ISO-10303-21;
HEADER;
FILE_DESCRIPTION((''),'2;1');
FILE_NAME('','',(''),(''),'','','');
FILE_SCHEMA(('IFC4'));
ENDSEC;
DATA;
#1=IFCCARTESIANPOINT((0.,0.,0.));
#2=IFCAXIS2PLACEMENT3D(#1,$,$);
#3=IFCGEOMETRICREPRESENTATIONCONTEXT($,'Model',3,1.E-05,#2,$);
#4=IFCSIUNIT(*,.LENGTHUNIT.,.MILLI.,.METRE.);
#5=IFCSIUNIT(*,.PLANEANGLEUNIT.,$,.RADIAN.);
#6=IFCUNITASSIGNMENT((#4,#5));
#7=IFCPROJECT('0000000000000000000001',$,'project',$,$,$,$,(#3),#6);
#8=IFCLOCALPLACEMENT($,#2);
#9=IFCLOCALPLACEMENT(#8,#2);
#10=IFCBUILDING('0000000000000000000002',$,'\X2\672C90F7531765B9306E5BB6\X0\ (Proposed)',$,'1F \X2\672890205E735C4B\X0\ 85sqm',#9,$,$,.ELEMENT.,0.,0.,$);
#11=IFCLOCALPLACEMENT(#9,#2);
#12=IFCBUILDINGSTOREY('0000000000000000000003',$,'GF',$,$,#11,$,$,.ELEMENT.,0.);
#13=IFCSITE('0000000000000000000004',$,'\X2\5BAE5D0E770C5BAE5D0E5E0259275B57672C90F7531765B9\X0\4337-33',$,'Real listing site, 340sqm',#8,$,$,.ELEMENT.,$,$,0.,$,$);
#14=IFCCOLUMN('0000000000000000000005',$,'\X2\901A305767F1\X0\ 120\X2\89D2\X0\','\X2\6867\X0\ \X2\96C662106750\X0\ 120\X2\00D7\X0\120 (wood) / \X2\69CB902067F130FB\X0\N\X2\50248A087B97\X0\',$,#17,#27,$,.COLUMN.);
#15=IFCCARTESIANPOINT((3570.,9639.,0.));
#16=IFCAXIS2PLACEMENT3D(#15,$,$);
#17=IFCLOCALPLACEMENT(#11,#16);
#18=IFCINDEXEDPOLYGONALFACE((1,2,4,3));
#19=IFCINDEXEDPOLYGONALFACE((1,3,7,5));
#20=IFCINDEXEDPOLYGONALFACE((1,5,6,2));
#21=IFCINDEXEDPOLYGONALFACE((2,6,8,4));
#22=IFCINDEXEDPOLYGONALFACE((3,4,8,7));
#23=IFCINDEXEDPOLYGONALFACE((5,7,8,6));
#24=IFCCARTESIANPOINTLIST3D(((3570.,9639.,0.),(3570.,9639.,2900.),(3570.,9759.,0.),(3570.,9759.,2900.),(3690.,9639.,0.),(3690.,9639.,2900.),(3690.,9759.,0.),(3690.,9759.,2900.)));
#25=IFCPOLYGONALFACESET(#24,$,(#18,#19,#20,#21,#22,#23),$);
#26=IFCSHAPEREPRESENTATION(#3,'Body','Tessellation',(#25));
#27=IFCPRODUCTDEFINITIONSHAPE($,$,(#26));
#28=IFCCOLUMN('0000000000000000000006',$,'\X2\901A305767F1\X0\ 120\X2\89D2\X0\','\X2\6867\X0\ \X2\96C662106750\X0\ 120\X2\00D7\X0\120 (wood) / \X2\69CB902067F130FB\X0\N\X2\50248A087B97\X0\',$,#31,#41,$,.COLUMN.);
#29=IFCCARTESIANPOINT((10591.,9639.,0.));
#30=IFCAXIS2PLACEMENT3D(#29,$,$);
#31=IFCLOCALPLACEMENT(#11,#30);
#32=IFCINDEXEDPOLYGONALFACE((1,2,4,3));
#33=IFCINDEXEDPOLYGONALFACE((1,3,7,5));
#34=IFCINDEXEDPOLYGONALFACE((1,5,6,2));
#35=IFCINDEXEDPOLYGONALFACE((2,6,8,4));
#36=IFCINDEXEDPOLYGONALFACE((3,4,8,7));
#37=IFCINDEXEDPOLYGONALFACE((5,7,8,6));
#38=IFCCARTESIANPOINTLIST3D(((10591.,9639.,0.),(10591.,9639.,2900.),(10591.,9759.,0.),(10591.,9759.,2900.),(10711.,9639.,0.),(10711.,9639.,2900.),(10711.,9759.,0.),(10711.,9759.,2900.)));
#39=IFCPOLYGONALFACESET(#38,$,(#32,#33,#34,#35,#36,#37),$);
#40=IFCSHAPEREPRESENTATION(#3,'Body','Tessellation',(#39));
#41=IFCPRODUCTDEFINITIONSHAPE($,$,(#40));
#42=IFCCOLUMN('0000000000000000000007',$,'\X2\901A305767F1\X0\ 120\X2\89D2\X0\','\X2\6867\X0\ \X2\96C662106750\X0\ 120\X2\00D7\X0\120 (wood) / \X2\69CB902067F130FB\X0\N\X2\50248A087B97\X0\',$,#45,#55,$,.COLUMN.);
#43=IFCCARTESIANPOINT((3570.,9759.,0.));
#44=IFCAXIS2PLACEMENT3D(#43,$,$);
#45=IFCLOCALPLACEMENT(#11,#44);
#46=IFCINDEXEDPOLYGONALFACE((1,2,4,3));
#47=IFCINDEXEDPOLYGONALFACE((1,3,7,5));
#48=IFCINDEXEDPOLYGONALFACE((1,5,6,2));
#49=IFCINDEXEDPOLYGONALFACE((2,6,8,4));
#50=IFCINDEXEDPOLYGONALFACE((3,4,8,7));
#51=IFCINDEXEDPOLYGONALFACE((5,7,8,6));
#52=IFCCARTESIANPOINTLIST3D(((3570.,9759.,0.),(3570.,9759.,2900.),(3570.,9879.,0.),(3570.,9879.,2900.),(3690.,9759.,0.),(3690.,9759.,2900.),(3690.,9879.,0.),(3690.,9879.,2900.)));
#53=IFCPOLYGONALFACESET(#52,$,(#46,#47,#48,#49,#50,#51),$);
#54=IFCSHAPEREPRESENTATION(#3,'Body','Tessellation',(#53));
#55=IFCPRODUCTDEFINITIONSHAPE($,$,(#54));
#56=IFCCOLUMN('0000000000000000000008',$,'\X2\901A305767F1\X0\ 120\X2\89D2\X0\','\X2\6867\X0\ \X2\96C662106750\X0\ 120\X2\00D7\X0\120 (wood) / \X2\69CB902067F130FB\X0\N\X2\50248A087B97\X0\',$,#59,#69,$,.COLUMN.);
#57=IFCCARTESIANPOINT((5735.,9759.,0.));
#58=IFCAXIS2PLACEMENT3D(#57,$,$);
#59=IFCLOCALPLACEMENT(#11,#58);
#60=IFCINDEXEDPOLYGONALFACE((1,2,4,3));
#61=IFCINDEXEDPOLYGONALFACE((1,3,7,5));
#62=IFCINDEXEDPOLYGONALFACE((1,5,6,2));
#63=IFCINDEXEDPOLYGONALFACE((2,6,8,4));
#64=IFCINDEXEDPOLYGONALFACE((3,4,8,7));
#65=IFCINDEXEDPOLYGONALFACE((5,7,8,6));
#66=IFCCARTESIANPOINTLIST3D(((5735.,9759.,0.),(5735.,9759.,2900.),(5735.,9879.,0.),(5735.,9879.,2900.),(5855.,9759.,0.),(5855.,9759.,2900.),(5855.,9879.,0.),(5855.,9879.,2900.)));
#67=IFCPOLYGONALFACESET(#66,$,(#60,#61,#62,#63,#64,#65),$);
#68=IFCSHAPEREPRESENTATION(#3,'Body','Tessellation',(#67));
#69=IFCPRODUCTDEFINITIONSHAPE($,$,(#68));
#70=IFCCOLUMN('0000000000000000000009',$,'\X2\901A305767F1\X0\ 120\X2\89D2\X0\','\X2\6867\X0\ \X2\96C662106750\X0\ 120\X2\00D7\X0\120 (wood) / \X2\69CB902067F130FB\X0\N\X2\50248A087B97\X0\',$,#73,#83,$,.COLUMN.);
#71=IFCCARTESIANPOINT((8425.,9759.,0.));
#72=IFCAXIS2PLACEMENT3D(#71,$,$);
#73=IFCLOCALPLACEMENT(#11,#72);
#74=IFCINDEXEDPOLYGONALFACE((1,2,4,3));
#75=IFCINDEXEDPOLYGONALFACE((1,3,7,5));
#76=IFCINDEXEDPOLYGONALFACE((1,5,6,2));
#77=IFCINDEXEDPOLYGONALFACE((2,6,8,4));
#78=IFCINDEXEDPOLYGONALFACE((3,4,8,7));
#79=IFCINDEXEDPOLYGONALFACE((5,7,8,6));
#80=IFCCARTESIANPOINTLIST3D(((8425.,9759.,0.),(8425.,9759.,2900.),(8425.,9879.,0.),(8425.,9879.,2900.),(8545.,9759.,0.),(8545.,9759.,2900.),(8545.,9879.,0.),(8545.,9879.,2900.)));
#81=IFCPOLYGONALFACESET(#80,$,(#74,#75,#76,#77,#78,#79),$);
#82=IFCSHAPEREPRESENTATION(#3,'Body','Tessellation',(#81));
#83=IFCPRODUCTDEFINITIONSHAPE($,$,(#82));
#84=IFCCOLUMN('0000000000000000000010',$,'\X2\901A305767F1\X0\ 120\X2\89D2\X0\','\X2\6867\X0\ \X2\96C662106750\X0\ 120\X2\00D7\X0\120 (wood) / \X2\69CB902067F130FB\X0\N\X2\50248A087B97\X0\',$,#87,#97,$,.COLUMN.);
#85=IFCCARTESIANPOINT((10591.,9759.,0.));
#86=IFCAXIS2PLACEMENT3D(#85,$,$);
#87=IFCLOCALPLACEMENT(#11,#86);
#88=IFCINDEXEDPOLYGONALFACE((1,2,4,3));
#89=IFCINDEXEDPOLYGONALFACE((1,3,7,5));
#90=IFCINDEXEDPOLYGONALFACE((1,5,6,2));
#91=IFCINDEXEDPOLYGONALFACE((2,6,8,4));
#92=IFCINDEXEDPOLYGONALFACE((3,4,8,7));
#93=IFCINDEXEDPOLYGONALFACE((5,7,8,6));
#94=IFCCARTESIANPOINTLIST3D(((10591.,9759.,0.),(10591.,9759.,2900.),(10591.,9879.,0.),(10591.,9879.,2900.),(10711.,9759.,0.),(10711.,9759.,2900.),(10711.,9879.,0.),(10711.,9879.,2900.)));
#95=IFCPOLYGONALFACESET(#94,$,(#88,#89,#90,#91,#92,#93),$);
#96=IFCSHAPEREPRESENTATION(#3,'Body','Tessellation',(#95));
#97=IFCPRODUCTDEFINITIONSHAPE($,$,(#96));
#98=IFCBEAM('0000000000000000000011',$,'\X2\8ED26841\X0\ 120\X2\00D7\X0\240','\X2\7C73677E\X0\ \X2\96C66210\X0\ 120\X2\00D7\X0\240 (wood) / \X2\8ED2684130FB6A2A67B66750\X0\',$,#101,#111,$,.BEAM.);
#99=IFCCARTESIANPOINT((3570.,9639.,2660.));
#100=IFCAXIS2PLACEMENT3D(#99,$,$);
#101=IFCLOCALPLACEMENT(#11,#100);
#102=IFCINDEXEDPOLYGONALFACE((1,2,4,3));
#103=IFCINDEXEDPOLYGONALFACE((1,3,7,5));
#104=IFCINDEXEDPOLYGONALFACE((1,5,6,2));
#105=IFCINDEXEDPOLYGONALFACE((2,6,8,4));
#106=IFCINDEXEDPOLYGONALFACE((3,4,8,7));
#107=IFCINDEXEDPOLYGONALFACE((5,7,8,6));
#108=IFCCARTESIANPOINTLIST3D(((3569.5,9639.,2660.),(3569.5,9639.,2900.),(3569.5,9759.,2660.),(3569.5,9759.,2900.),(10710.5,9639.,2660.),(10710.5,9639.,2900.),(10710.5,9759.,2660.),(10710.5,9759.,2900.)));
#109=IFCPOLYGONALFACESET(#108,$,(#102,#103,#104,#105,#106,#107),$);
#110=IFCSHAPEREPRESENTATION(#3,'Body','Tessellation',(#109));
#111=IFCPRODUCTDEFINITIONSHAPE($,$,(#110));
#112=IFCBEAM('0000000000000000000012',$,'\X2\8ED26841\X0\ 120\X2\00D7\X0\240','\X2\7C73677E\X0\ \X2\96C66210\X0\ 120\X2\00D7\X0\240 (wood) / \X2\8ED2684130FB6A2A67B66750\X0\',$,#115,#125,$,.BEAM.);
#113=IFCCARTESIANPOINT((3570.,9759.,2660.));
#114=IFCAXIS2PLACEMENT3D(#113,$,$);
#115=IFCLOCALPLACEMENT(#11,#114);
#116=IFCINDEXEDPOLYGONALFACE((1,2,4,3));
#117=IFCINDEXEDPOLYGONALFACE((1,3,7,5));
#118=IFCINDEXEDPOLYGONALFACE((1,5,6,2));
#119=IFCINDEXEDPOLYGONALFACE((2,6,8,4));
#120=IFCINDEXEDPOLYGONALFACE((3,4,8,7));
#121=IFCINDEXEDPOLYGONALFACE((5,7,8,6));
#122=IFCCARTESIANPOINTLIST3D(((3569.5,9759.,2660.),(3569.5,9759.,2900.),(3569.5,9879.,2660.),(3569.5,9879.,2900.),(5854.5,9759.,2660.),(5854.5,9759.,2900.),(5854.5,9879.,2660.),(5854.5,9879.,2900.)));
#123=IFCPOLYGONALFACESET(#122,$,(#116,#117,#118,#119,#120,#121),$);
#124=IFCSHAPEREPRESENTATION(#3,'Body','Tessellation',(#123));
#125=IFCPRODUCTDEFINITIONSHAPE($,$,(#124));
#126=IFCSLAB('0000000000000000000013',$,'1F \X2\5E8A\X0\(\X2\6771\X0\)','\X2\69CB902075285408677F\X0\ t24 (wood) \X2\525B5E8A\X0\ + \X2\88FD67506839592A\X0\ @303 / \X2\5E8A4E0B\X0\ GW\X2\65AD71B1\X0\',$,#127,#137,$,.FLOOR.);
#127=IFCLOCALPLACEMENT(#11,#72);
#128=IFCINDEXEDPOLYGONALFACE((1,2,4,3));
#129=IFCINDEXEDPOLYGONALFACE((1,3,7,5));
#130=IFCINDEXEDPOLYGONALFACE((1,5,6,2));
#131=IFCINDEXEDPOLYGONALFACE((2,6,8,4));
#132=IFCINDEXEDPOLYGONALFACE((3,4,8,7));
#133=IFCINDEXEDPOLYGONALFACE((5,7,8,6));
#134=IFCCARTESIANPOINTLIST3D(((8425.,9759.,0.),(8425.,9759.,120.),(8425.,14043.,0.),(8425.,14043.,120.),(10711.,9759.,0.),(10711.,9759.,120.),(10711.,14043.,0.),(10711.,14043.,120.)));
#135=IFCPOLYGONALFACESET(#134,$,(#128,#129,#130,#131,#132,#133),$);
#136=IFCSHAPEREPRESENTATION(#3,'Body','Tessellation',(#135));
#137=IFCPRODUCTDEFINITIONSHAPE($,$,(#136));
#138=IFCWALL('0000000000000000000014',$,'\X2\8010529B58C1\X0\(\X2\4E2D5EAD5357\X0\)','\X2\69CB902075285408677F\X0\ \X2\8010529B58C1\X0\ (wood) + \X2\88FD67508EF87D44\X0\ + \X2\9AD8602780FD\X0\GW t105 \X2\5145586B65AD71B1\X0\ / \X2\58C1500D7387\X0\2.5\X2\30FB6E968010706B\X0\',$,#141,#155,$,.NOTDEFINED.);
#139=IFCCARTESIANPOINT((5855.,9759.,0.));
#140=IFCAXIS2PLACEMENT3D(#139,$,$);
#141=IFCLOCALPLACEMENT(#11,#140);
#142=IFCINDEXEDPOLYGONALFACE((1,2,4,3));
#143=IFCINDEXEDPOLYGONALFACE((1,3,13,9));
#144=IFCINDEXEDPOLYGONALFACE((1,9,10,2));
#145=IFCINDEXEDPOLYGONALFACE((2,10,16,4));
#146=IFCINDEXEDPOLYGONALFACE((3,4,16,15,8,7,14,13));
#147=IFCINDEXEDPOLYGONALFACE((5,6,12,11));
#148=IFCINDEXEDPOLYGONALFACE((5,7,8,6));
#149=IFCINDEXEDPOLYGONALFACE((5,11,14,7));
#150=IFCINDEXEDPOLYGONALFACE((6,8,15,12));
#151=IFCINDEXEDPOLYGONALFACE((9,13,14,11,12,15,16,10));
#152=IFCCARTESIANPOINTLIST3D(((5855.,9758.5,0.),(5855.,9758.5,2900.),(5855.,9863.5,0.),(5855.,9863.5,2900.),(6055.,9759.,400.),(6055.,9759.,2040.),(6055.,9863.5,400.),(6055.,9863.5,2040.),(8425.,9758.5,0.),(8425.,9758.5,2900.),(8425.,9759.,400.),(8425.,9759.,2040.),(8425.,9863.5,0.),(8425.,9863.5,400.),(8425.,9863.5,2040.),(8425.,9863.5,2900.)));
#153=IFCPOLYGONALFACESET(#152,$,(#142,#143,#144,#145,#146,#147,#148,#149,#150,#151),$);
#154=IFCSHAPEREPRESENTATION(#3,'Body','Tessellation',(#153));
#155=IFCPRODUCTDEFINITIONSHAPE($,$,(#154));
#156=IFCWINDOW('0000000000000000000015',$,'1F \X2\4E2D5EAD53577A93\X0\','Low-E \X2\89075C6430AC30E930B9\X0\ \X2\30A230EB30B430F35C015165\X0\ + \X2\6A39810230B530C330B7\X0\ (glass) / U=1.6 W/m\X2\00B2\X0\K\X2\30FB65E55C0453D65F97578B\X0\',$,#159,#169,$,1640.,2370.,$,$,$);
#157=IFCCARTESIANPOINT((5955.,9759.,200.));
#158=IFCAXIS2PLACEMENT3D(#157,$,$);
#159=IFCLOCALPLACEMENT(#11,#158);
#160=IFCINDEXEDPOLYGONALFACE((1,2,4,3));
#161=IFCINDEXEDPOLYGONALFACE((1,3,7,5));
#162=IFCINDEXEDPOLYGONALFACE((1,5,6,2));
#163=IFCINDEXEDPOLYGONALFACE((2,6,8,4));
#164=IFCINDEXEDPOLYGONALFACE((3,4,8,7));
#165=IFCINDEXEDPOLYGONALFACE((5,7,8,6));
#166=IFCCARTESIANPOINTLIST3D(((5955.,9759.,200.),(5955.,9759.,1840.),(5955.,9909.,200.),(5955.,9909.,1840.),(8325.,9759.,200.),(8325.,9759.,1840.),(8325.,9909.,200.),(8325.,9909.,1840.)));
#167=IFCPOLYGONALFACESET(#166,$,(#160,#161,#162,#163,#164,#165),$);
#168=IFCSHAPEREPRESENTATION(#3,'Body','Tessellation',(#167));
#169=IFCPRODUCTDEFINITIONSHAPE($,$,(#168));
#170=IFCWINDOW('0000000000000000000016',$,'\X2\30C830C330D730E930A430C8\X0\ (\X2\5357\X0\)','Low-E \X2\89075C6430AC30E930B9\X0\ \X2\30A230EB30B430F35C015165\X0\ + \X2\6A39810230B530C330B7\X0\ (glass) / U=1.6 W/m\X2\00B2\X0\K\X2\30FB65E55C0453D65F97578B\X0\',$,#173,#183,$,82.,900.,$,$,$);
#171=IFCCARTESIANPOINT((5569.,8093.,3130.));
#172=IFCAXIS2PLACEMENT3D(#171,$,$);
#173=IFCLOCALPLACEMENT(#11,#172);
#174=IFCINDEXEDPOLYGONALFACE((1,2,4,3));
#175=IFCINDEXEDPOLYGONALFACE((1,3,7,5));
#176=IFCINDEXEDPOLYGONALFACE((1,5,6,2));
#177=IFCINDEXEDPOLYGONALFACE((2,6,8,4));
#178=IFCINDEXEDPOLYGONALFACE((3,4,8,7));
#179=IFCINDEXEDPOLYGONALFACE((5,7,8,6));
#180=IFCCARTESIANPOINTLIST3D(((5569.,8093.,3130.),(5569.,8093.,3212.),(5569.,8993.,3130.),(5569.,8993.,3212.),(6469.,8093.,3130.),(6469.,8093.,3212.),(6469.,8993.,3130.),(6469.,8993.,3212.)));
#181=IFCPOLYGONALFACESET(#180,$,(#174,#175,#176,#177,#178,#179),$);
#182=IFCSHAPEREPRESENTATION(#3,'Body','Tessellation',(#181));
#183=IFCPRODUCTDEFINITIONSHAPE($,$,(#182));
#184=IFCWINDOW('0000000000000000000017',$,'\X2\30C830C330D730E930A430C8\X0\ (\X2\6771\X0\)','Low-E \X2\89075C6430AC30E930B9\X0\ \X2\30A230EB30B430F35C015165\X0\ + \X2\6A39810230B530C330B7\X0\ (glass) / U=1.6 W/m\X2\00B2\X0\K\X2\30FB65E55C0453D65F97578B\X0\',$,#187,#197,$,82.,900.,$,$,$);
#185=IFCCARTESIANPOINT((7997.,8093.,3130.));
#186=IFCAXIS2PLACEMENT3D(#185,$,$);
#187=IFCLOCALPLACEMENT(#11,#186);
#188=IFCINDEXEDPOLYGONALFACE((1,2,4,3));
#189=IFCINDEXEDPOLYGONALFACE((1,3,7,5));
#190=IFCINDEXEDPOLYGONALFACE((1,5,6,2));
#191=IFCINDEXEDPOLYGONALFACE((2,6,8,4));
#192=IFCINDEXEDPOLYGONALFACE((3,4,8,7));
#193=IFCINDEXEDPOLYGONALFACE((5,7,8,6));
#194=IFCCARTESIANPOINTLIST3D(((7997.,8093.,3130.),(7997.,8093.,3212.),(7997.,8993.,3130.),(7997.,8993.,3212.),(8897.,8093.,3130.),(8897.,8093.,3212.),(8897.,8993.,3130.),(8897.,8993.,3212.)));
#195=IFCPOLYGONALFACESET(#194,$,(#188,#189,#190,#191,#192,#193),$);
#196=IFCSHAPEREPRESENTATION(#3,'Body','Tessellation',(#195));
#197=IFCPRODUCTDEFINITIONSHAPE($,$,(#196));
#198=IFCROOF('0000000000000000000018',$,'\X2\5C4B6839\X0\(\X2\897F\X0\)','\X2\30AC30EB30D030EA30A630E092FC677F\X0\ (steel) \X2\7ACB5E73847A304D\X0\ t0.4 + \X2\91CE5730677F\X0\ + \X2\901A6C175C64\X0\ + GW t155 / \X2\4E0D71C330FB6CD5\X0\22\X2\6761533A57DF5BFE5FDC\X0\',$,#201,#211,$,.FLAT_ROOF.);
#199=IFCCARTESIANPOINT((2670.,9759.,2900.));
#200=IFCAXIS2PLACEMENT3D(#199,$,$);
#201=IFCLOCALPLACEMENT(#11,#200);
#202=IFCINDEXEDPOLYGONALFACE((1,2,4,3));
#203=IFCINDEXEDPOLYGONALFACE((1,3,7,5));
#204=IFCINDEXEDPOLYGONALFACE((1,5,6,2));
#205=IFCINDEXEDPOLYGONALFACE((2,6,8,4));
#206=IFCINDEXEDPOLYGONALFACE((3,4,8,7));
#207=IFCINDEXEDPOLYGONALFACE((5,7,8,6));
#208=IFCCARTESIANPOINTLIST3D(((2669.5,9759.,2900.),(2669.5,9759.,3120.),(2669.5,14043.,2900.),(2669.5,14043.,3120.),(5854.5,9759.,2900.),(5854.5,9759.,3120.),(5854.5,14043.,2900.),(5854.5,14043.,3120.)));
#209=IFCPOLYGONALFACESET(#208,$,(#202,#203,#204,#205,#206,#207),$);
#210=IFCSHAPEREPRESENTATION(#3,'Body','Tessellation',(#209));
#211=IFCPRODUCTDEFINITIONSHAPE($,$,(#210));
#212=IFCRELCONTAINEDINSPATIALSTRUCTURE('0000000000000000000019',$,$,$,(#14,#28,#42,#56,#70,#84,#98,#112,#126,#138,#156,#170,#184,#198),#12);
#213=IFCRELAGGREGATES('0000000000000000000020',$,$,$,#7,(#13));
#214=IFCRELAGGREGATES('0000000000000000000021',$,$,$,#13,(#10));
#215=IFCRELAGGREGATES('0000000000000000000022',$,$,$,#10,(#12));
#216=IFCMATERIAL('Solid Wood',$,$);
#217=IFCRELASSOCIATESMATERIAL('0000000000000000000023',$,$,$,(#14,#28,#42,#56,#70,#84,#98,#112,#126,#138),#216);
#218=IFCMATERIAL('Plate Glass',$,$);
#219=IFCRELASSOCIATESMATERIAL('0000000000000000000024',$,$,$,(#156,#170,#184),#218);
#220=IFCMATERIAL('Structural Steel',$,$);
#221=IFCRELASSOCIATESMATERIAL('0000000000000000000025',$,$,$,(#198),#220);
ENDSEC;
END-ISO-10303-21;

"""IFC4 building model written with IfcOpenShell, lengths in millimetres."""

from ifc_helpers import new_model, si_unit, frame, frame_2d, origin, place, context, project, spatial, rectangle, extrude, material, element, fill, save


model = new_model("IFC4")

# Units and contexts
model_context = context("Model", 3, precision=1e-05, world=origin())
ifc_project = project(units=[si_unit("LENGTHUNIT", "METRE", prefix="MILLI"), si_unit("PLANEANGLEUNIT", "RADIAN")], contexts=[model_context])

# Site, building, storey
site_placement = place(None, origin())
site = spatial("IfcSite", under=ifc_project, at=site_placement, Name="宮崎県宮崎市大字本郷北方4337-33", ObjectType="Real listing site, 340sqm", CompositionType="ELEMENT", RefElevation=0.0)
building_placement = place(site_placement, origin())
building = spatial("IfcBuilding", under=site, at=building_placement, Name="本郷北方の家 (Proposed)", ObjectType="1F 木造平屋 85sqm", CompositionType="ELEMENT", ElevationOfRefHeight=0.0, ElevationOfTerrain=0.0)
storey_placement = place(building_placement, origin())
storey = spatial("IfcBuildingStorey", under=building, at=storey_placement, Name="GF", CompositionType="ELEMENT", Elevation=0.0)

# Columns
ifc_material_1 = material(Name="Solid Wood")
column_1_placement = place(storey_placement, frame((3570.0, 9639.0, 0.0)))
element("IfcColumn", 1, at=column_1_placement, inside=storey, material=ifc_material_1, Name="通し柱 120角", Description="桧 集成材 120×120 (wood) / 構造柱・N値計算", PredefinedType="COLUMN", context=model_context, shape_type="SweptSolid", body=[
    extrude(rectangle(XDim=120.0, YDim=120.0, at=frame_2d((60.0, 60.0))), frame((3570.0, 9639.0, 0.0)), (0.0, 0.0, 1.0), 2900.0),
])
column_2_placement = place(storey_placement, frame((10591.0, 9639.0, 0.0)))
element("IfcColumn", 2, at=column_2_placement, inside=storey, material=ifc_material_1, Name="通し柱 120角", Description="桧 集成材 120×120 (wood) / 構造柱・N値計算", PredefinedType="COLUMN", context=model_context, shape_type="SweptSolid", body=[
    extrude(rectangle(XDim=120.0, YDim=120.0, at=frame_2d((60.0, 60.0))), frame((10591.0, 9639.0, 0.0)), (0.0, 0.0, 1.0), 2900.0),
])
column_3_placement = place(storey_placement, frame((3570.0, 9759.0, 0.0)))
element("IfcColumn", 3, at=column_3_placement, inside=storey, material=ifc_material_1, Name="通し柱 120角", Description="桧 集成材 120×120 (wood) / 構造柱・N値計算", PredefinedType="COLUMN", context=model_context, shape_type="SweptSolid", body=[
    extrude(rectangle(XDim=120.0, YDim=120.0, at=frame_2d((60.0, 60.0))), frame((3570.0, 9759.0, 0.0)), (0.0, 0.0, 1.0), 2900.0),
])
column_4_placement = place(storey_placement, frame((5735.0, 9759.0, 0.0)))
element("IfcColumn", 4, at=column_4_placement, inside=storey, material=ifc_material_1, Name="通し柱 120角", Description="桧 集成材 120×120 (wood) / 構造柱・N値計算", PredefinedType="COLUMN", context=model_context, shape_type="SweptSolid", body=[
    extrude(rectangle(XDim=120.0, YDim=120.0, at=frame_2d((60.0, 60.0))), frame((5735.0, 9759.0, 0.0)), (0.0, 0.0, 1.0), 2900.0),
])
column_5_placement = place(storey_placement, frame((8425.0, 9759.0, 0.0)))
element("IfcColumn", 5, at=column_5_placement, inside=storey, material=ifc_material_1, Name="通し柱 120角", Description="桧 集成材 120×120 (wood) / 構造柱・N値計算", PredefinedType="COLUMN", context=model_context, shape_type="SweptSolid", body=[
    extrude(rectangle(XDim=120.0, YDim=120.0, at=frame_2d((60.0, 60.0))), frame((8425.0, 9759.0, 0.0)), (0.0, 0.0, 1.0), 2900.0),
])
column_6_placement = place(storey_placement, frame((10591.0, 9759.0, 0.0)))
element("IfcColumn", 6, at=column_6_placement, inside=storey, material=ifc_material_1, Name="通し柱 120角", Description="桧 集成材 120×120 (wood) / 構造柱・N値計算", PredefinedType="COLUMN", context=model_context, shape_type="SweptSolid", body=[
    extrude(rectangle(XDim=120.0, YDim=120.0, at=frame_2d((60.0, 60.0))), frame((10591.0, 9759.0, 0.0)), (0.0, 0.0, 1.0), 2900.0),
])

# Beams
beam_1_placement = place(storey_placement, frame((3570.0, 9639.0, 2660.0)))
element("IfcBeam", 7, at=beam_1_placement, inside=storey, material=ifc_material_1, Name="軒桁 120×240", Description="米松 集成 120×240 (wood) / 軒桁・横架材", PredefinedType="BEAM", context=model_context, shape_type="SweptSolid", body=[
    extrude(rectangle(XDim=7141.0, YDim=120.0, at=frame_2d((3570.0, 60.0))), frame((3570.0, 9639.0, 2660.0)), (0.0, 0.0, 1.0), 240.0),
])
beam_2_placement = place(storey_placement, frame((3570.0, 9759.0, 2660.0)))
element("IfcBeam", 8, at=beam_2_placement, inside=storey, material=ifc_material_1, Name="軒桁 120×240", Description="米松 集成 120×240 (wood) / 軒桁・横架材", PredefinedType="BEAM", context=model_context, shape_type="SweptSolid", body=[
    extrude(rectangle(XDim=2285.0, YDim=120.0, at=frame_2d((1142.0, 60.0))), frame((3570.0, 9759.0, 2660.0)), (0.0, 0.0, 1.0), 240.0),
])

# Slab
slab_1_placement = place(storey_placement, frame((8425.0, 9759.0, 0.0)))
element("IfcSlab", 9, at=slab_1_placement, inside=storey, material=ifc_material_1, Name="1F 床(東)", Description="構造用合板 t24 (wood) 剛床 + 製材根太 @303 / 床下 GW断熱", PredefinedType="FLOOR", context=model_context, shape_type="SweptSolid", body=[
    extrude(rectangle(XDim=2286.0, YDim=4284.0, at=frame_2d((1143.0, 2142.0))), frame((8425.0, 9759.0, 0.0)), (0.0, 0.0, 1.0), 120.0),
])

# Wall, opening, window
wall_1_placement = place(storey_placement, frame((5855.0, 9759.0, 0.0)))
wall_1 = element("IfcWall", 10, at=wall_1_placement, inside=storey, material=ifc_material_1, Name="耐力壁(中庭南)", Description="構造用合板 耐力壁 (wood) + 製材軸組 + 高性能GW t105 充填断熱 / 壁倍率2.5・準耐火", PredefinedType="NOTDEFINED", context=model_context, shape_type="SweptSolid", body=[
    extrude(rectangle(XDim=2570.0, YDim=105.0, at=frame_2d((1285.0, 52.0))), frame((5855.0, 9759.0, 0.0)), (0.0, 0.0, 1.0), 2900.0),
])
opening_placement = place(storey_placement, frame((5955.0, 9759.0, 200.0)))
opening = element("IfcOpeningElement", 11, at=opening_placement, cuts=wall_1, PredefinedType="NOTDEFINED", context=model_context, shape_type="SweptSolid", body=[
    extrude(rectangle(XDim=2370.0, YDim=150.0, at=frame_2d((1185.0, 75.0))), frame((5955.0, 9759.0, 200.0)), (0.0, 0.0, 1.0), 1640.0),
])
ifc_material_2 = material(Name="Plate Glass")
window_1_placement = place(storey_placement, frame((5955.0, 9759.0, 200.0)))
window_1 = element("IfcWindow", 12, at=window_1_placement, inside=storey, material=ifc_material_2, Name="1F 中庭南窓", Description="Low-E 複層ガラス アルゴン封入 + 樹脂サッシ (glass) / U=1.6 W/m²K・日射取得型", OverallHeight=1640.0, OverallWidth=2370.0, context=model_context, shape_type="SweptSolid", body=[
    extrude(rectangle(XDim=2370.0, YDim=150.0, at=frame_2d((1185.0, 75.0))), frame((5955.0, 9759.0, 200.0)), (0.0, 0.0, 1.0), 1640.0),
])
fill(opening, window_1)

# Windows
window_2_placement = place(storey_placement, frame((5569.0, 8093.0, 3130.0)))
element("IfcWindow", 13, at=window_2_placement, inside=storey, material=ifc_material_2, Name="トップライト (南)", Description="Low-E 複層ガラス アルゴン封入 + 樹脂サッシ (glass) / U=1.6 W/m²K・日射取得型", OverallHeight=82.0, OverallWidth=900.0, context=model_context, shape_type="SweptSolid", body=[
    extrude(rectangle(XDim=900.0, YDim=900.0, at=frame_2d((450.0, 450.0))), frame((5569.0, 8093.0, 3130.0)), (0.0, 0.0, 1.0), 82.0),
])
window_3_placement = place(storey_placement, frame((7997.0, 8093.0, 3130.0)))
element("IfcWindow", 14, at=window_3_placement, inside=storey, material=ifc_material_2, Name="トップライト (東)", Description="Low-E 複層ガラス アルゴン封入 + 樹脂サッシ (glass) / U=1.6 W/m²K・日射取得型", OverallHeight=82.0, OverallWidth=900.0, context=model_context, shape_type="SweptSolid", body=[
    extrude(rectangle(XDim=900.0, YDim=900.0, at=frame_2d((450.0, 450.0))), frame((7997.0, 8093.0, 3130.0)), (0.0, 0.0, 1.0), 82.0),
])

# Roof
ifc_material_3 = material(Name="Structural Steel")
roof_1_placement = place(storey_placement, frame((2670.0, 9759.0, 2900.0)))
element("IfcRoof", 15, at=roof_1_placement, inside=storey, material=ifc_material_3, Name="屋根(西)", Description="ガルバリウム鋼板 (steel) 立平葺き t0.4 + 野地板 + 通気層 + GW t155 / 不燃・法22条区域対応", PredefinedType="FLAT_ROOF", context=model_context, shape_type="SweptSolid", body=[
    extrude(rectangle(XDim=3185.0, YDim=4284.0, at=frame_2d((1592.0, 2142.0))), frame((2670.0, 9759.0, 2900.0)), (0.0, 0.0, 1.0), 220.0),
])

save(model, "model.ifc")
